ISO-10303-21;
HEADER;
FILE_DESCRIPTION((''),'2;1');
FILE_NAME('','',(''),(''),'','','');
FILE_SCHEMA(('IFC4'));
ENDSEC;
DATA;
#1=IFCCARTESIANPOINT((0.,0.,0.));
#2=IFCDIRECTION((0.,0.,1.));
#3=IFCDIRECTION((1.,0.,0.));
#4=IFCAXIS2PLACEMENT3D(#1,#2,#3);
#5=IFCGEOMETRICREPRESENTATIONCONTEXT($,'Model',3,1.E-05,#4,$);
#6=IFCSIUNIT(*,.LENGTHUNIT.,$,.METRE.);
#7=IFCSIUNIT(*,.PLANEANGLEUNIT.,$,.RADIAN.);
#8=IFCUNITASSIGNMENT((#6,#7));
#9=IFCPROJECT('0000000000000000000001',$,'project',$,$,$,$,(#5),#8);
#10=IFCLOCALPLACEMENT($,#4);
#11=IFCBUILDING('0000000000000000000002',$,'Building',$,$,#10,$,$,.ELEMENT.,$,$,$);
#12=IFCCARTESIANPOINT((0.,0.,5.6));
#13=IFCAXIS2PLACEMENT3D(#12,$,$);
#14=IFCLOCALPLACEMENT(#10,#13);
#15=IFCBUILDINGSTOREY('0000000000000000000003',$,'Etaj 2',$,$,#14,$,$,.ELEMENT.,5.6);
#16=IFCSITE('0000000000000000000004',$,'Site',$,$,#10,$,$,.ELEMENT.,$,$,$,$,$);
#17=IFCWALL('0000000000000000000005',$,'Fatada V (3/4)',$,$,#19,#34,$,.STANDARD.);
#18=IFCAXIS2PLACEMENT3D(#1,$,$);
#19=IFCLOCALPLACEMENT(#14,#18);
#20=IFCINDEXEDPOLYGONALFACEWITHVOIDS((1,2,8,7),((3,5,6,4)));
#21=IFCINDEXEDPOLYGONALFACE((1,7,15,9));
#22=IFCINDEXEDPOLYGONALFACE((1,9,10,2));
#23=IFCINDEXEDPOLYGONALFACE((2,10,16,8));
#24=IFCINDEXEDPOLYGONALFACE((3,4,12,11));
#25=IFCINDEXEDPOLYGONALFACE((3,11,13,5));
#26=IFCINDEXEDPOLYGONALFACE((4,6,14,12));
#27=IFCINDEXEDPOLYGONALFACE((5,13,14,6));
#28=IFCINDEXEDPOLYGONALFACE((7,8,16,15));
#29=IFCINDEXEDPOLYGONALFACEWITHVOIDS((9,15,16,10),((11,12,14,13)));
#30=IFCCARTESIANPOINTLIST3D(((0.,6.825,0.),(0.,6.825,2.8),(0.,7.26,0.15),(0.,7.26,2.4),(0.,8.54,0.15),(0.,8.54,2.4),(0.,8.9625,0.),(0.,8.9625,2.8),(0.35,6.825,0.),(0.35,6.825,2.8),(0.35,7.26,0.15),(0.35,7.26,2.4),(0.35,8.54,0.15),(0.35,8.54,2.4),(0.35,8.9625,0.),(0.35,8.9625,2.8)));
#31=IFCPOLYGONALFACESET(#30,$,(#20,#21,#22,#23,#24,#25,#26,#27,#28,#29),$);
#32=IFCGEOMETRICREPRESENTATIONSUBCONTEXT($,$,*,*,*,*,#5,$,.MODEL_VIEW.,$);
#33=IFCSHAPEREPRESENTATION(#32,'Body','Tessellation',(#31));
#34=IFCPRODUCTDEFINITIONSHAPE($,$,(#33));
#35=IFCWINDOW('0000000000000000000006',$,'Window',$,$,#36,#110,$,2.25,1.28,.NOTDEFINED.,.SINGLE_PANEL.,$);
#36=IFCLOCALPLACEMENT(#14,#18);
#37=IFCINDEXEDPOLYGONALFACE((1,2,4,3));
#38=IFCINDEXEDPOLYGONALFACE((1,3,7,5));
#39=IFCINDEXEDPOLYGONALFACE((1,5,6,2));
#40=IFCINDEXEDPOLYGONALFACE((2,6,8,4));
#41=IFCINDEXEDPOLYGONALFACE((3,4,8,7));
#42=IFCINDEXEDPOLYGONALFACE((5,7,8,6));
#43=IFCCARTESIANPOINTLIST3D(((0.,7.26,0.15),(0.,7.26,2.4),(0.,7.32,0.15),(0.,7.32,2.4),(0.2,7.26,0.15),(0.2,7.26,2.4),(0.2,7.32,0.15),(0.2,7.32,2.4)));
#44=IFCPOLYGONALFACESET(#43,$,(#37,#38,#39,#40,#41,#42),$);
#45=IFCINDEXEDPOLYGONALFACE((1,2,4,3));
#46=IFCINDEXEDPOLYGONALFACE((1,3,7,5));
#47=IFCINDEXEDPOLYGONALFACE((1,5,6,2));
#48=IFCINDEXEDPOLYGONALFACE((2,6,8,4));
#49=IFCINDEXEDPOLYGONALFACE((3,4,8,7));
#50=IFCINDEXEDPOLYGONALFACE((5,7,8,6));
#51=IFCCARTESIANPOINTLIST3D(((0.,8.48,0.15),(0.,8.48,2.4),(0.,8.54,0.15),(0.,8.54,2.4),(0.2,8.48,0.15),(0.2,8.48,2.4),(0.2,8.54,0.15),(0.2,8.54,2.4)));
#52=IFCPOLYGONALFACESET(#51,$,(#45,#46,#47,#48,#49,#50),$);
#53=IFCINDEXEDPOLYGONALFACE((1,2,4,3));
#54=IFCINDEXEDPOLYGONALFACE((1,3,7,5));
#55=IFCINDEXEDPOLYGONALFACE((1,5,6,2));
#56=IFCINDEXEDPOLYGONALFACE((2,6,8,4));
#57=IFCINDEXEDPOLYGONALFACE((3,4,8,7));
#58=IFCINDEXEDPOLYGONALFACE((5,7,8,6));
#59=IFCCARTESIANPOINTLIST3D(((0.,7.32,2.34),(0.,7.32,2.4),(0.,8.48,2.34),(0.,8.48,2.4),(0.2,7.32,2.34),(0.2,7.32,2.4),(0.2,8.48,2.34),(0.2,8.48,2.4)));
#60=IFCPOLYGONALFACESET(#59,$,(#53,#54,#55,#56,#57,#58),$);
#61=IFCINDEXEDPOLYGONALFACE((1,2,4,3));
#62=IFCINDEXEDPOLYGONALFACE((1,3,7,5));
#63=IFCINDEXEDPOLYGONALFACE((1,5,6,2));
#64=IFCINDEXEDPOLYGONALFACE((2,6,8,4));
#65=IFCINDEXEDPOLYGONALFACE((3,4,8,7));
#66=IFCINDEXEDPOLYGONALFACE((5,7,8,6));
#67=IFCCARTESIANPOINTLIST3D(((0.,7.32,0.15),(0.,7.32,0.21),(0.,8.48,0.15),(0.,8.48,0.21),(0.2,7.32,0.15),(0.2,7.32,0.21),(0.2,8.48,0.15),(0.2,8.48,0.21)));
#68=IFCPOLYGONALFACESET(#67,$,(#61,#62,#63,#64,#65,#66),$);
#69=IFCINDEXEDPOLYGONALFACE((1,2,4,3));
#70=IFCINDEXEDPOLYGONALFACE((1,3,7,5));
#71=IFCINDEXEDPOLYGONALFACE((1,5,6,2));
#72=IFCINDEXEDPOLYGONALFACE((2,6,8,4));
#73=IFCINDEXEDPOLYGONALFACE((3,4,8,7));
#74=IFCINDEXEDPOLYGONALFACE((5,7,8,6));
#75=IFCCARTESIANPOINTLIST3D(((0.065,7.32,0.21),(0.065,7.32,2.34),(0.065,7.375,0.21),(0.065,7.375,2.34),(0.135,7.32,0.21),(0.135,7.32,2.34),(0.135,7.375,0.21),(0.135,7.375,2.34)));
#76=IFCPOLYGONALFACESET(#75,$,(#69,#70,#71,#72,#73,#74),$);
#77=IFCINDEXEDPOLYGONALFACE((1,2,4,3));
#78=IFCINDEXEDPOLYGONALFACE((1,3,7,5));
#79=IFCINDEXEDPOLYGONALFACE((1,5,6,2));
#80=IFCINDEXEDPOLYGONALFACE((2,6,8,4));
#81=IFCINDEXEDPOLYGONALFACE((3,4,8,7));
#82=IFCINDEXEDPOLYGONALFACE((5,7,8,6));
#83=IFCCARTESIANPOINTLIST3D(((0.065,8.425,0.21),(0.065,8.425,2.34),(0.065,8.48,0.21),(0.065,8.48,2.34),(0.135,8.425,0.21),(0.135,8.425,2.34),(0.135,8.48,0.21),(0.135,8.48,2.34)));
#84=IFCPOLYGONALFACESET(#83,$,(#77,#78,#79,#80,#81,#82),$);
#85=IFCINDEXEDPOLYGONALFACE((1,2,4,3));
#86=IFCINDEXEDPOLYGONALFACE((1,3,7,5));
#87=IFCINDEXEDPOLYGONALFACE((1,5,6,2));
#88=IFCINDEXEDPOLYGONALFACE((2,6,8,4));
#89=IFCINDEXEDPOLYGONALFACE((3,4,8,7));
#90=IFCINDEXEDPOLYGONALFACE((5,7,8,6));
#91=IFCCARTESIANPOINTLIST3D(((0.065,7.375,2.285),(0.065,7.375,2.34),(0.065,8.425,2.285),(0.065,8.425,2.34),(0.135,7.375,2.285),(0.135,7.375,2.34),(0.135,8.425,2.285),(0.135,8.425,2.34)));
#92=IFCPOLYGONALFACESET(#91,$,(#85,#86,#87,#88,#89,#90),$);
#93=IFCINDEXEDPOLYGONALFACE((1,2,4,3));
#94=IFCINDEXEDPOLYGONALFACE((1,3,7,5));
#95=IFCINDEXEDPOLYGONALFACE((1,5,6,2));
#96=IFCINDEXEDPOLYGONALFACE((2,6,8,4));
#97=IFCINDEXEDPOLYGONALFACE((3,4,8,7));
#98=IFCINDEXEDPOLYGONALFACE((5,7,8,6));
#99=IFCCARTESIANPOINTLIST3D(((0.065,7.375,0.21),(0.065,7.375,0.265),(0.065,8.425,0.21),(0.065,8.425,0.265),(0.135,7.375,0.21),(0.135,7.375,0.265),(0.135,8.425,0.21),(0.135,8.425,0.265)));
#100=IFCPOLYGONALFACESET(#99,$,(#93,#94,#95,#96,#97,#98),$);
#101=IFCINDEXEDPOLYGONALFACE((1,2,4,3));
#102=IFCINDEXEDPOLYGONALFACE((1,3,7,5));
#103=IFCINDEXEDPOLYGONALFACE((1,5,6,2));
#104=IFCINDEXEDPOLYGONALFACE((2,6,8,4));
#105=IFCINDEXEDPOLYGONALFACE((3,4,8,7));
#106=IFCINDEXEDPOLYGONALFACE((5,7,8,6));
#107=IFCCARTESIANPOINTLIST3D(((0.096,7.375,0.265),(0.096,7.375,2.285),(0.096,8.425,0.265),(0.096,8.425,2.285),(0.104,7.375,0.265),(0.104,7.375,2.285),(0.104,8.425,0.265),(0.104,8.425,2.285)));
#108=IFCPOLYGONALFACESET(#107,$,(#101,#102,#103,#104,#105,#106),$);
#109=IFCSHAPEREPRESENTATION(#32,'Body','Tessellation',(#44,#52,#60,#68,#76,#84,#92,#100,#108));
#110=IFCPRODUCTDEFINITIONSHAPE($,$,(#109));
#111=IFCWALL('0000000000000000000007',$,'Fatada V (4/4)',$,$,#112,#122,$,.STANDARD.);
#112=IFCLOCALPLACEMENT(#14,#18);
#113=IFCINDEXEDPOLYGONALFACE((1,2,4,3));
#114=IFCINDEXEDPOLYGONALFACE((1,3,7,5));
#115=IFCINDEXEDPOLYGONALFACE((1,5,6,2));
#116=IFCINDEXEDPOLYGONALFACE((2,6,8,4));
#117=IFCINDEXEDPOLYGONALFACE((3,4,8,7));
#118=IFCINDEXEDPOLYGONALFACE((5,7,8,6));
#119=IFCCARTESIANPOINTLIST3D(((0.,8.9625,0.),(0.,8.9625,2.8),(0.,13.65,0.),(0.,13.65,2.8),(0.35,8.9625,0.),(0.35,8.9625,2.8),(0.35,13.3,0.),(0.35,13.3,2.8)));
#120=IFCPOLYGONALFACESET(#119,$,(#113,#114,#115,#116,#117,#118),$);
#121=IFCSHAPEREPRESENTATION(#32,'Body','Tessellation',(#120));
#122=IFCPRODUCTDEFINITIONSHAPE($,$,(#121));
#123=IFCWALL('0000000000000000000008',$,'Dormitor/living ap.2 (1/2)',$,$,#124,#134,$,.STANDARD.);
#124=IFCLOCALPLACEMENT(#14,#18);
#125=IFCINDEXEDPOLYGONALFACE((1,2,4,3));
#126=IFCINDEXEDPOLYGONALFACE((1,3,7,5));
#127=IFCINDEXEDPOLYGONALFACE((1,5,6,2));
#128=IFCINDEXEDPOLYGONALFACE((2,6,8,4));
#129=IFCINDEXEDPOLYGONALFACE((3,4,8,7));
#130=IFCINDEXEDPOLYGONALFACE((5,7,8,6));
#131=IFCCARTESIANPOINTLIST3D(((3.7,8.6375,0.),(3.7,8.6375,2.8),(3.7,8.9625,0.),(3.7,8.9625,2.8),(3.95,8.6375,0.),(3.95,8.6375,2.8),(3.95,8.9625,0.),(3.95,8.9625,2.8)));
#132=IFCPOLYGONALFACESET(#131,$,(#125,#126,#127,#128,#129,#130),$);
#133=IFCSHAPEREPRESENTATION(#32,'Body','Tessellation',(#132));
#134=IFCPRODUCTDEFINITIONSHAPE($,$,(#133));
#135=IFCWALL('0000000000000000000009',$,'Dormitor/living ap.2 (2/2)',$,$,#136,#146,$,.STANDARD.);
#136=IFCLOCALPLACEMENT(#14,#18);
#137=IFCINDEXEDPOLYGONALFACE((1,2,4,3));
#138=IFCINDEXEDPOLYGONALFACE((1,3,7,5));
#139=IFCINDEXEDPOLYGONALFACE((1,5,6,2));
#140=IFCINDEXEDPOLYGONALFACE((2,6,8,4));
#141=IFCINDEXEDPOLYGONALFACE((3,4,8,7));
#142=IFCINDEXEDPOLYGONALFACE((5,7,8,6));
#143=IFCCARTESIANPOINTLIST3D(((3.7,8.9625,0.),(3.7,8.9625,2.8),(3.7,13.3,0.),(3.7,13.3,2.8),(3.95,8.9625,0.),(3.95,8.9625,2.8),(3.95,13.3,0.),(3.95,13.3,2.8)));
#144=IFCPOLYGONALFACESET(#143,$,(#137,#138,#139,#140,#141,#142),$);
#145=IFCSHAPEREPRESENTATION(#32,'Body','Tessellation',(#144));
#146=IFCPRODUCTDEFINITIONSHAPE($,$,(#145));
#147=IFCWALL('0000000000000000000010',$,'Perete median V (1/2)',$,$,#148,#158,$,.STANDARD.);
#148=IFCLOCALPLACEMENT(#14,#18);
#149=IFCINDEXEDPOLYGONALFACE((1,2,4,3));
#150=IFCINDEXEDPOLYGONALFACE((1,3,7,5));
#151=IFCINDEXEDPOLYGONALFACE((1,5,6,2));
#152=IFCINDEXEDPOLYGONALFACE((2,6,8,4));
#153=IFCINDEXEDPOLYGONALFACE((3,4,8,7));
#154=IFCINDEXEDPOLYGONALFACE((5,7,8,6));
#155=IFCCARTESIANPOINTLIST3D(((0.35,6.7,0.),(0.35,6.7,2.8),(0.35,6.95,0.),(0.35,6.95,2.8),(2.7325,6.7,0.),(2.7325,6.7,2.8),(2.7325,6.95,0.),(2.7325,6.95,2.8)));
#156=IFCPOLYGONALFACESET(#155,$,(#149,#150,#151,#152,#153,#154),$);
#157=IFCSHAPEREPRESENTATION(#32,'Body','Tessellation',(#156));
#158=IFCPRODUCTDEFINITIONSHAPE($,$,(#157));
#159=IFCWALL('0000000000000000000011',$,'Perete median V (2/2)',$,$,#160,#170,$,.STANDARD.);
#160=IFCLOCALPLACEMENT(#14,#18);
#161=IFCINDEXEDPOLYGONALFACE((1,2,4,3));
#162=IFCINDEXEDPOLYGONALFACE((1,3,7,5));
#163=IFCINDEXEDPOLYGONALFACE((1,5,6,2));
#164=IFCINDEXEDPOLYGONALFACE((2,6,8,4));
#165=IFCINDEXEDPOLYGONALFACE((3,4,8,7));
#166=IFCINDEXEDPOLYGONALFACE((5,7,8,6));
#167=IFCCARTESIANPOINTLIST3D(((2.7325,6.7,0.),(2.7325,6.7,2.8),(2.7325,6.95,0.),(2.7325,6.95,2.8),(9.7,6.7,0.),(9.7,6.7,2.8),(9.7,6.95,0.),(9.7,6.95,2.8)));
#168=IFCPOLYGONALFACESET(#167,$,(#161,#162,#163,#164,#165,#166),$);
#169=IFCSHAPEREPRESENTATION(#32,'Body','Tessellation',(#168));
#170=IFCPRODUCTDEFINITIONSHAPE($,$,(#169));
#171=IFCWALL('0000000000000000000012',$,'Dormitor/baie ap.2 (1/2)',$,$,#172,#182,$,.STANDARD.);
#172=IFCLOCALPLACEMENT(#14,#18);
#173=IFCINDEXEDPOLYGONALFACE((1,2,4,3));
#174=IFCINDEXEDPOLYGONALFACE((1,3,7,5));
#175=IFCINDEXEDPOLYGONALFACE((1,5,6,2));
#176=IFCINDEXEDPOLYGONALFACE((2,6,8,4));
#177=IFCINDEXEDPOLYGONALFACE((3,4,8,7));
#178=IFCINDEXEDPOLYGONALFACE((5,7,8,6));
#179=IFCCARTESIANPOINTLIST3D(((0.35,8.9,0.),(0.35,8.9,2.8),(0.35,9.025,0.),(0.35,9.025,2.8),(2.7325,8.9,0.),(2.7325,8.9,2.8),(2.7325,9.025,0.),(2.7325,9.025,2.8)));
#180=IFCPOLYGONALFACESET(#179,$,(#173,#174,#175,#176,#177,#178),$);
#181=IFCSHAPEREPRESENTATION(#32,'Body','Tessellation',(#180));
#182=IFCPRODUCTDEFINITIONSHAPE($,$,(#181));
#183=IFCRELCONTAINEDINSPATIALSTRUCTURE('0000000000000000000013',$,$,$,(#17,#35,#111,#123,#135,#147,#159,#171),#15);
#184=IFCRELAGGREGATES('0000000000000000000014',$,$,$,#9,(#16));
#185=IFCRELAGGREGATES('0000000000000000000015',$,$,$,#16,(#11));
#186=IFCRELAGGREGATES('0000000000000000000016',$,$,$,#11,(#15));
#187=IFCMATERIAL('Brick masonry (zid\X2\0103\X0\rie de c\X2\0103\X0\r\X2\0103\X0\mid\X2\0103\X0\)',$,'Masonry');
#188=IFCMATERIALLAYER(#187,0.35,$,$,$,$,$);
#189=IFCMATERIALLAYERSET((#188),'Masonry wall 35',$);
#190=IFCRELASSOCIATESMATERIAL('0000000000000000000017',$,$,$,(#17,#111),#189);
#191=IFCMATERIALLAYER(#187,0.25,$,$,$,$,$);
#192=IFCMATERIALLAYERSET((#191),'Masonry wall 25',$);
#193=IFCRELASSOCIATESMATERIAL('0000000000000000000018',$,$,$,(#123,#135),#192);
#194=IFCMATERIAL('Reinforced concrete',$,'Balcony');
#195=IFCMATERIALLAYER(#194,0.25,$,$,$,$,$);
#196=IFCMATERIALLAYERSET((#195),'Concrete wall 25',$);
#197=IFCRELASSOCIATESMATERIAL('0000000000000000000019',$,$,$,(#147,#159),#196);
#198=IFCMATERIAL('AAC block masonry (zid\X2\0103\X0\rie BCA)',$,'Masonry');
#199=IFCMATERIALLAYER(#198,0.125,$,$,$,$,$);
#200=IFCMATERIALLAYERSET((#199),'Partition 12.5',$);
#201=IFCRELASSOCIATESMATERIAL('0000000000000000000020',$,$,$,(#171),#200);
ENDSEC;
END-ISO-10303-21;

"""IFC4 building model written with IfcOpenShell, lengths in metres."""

from ifc_helpers import new_model, si_unit, frame, frame_2d, origin, origin_with_axes, origin_2d, place, context, subcontext, project, spatial, rectangle, extrude, clip, halfspace, material, layer, layer_set, layer_usage, element, fill, save


model = new_model("IFC4")

# Units and contexts
model_context = context("Model", 3, precision=1e-05, world=origin_with_axes())
sub_context = subcontext(model_context, None, None, "MODEL_VIEW")
ifc_project = project(units=[si_unit("LENGTHUNIT", "METRE"), si_unit("PLANEANGLEUNIT", "RADIAN")], contexts=[model_context])

# Site, building, storey
placement = place(None, origin_with_axes())
site = spatial("IfcSite", under=ifc_project, at=placement, Name="Site", CompositionType="ELEMENT")
building = spatial("IfcBuilding", under=site, at=placement, Name="Building", CompositionType="ELEMENT")
storey_placement = place(placement, frame((0.0, 0.0, 5.6)))
storey = spatial("IfcBuildingStorey", under=building, at=storey_placement, Name="Etaj 2", CompositionType="ELEMENT", Elevation=5.6)

# Wall, opening, window
ifc_material_1 = material(Name="Brick masonry (zidărie de cărămidă)", Category="Masonry")
ifc_layer_1 = layer(ifc_material_1, 0.35)
ifc_layer_set_1 = layer_set([ifc_layer_1], Name="Masonry wall 35")
ifc_layer_usage_1 = layer_usage(ifc_layer_set_1, "AXIS2", "POSITIVE", -0.175)
wall_1_placement = place(storey_placement, frame((0.175, 6.825, 0.0), x_axis=(0.0, 1.0, 0.0)))
wall_1 = element("IfcWall", 1, at=wall_1_placement, inside=storey, material=ifc_layer_usage_1, Name="Fatada V (3/4)", PredefinedType="STANDARD", context=sub_context, shape_type="SweptSolid", body=[
    extrude(rectangle(XDim=2.1375, YDim=0.35, at=frame_2d((1.0688, 0.0))), origin(), (0.0, 0.0, 1.0), 2.8),
])
opening_1_placement = place(wall_1_placement, frame((1.075, 0.225, 0.15), z_axis=(0.0, -1.0, 0.0), x_axis=(1.0, 0.0, 0.0)))
opening_1 = element("IfcOpeningElement", 2, at=opening_1_placement, cuts=wall_1, PredefinedType="OPENING", context=sub_context, shape_type="SweptSolid", body=[
    extrude(rectangle(XDim=1.28, YDim=2.25, at=frame_2d((0.0, 1.125))), origin(), (0.0, 0.0, 1.0), 0.45),
])
window_1_placement = place(wall_1_placement, frame((1.075, 0.175, 0.15), z_axis=(0.0, -1.0, 0.0), x_axis=(1.0, 0.0, 0.0)))
window_1 = element("IfcWindow", 3, at=window_1_placement, inside=storey, Name="Window", OverallHeight=2.25, OverallWidth=1.28, PartitioningType="SINGLE_PANEL", PredefinedType="NOTDEFINED", context=sub_context, shape_type="SweptSolid", body=[
    extrude(rectangle(XDim=0.06, YDim=2.25, at=origin_2d()), frame((-0.61, 1.125, 0.0)), (0.0, 0.0, 1.0), 0.2),
    extrude(rectangle(XDim=0.06, YDim=2.25, at=origin_2d()), frame((0.61, 1.125, 0.0)), (0.0, 0.0, 1.0), 0.2),
    extrude(rectangle(XDim=1.16, YDim=0.06, at=origin_2d()), frame((0.0, 2.22, 0.0)), (0.0, 0.0, 1.0), 0.2),
    extrude(rectangle(XDim=1.16, YDim=0.06, at=origin_2d()), frame((0.0, 0.03, 0.0)), (0.0, 0.0, 1.0), 0.2),
    extrude(rectangle(XDim=0.055, YDim=2.13, at=origin_2d()), frame((-0.5525, 1.125, 0.065)), (0.0, 0.0, 1.0), 0.07),
    extrude(rectangle(XDim=0.055, YDim=2.13, at=origin_2d()), frame((0.5525, 1.125, 0.065)), (0.0, 0.0, 1.0), 0.07),
    extrude(rectangle(XDim=1.05, YDim=0.055, at=origin_2d()), frame((0.0, 2.1625, 0.065)), (0.0, 0.0, 1.0), 0.07),
    extrude(rectangle(XDim=1.05, YDim=0.055, at=origin_2d()), frame((0.0, 0.0875, 0.065)), (0.0, 0.0, 1.0), 0.07),
    extrude(rectangle(XDim=1.05, YDim=2.02, at=origin_2d()), frame((0.0, 1.125, 0.096)), (0.0, 0.0, 1.0), 0.008),
])
fill(opening_1, window_1)

# Walls
wall_2_placement = place(storey_placement, frame((0.175, 8.9625, 0.0), x_axis=(0.0, 1.0, 0.0)))
element("IfcWall", 4, at=wall_2_placement, inside=storey, material=ifc_layer_usage_1, Name="Fatada V (4/4)", PredefinedType="STANDARD", context=sub_context, shape_type="CSG", body=[
    clip(extrude(rectangle(XDim=4.6875, YDim=0.35, at=frame_2d((2.3438, 0.0))), origin(), (0.0, 0.0, 1.0), 2.8), halfspace(frame((4.5125, 0.0, 0.0), z_axis=(0.707107, -0.707107, 0.0)), False)),
])
ifc_layer_2 = layer(ifc_material_1, 0.25)
ifc_layer_set_2 = layer_set([ifc_layer_2], Name="Masonry wall 25")
ifc_layer_usage_2 = layer_usage(ifc_layer_set_2, "AXIS2", "POSITIVE", -0.125)
wall_3_placement = place(storey_placement, frame((3.825, 8.6375, 0.0), x_axis=(0.0, 1.0, 0.0)))
element("IfcWall", 5, at=wall_3_placement, inside=storey, material=ifc_layer_usage_2, Name="Dormitor/living ap.2 (1/2)", PredefinedType="STANDARD", context=sub_context, shape_type="SweptSolid", body=[
    extrude(rectangle(XDim=0.325, YDim=0.25, at=frame_2d((0.1625, 0.0))), origin(), (0.0, 0.0, 1.0), 2.8),
])
wall_4_placement = place(storey_placement, frame((3.825, 8.9625, 0.0), x_axis=(0.0, 1.0, 0.0)))
element("IfcWall", 6, at=wall_4_placement, inside=storey, material=ifc_layer_usage_2, Name="Dormitor/living ap.2 (2/2)", PredefinedType="STANDARD", context=sub_context, shape_type="SweptSolid", body=[
    extrude(rectangle(XDim=4.3375, YDim=0.25, at=frame_2d((2.1688, 0.0))), origin(), (0.0, 0.0, 1.0), 2.8),
])
ifc_material_2 = material(Name="Reinforced concrete", Category="Balcony")
ifc_layer_3 = layer(ifc_material_2, 0.25)
ifc_layer_set_3 = layer_set([ifc_layer_3], Name="Concrete wall 25")
ifc_layer_usage_3 = layer_usage(ifc_layer_set_3, "AXIS2", "POSITIVE", -0.125)
wall_5_placement = place(storey_placement, frame((0.35, 6.825, 0.0), x_axis=(1.0, 0.0, 0.0)))
element("IfcWall", 7, at=wall_5_placement, inside=storey, material=ifc_layer_usage_3, Name="Perete median V (1/2)", PredefinedType="STANDARD", context=sub_context, shape_type="SweptSolid", body=[
    extrude(rectangle(XDim=2.3825, YDim=0.25, at=frame_2d((1.1912, 0.0))), origin(), (0.0, 0.0, 1.0), 2.8),
])
wall_6_placement = place(storey_placement, frame((2.7325, 6.825, 0.0), x_axis=(1.0, 0.0, 0.0)))
element("IfcWall", 8, at=wall_6_placement, inside=storey, material=ifc_layer_usage_3, Name="Perete median V (2/2)", PredefinedType="STANDARD", context=sub_context, shape_type="SweptSolid", body=[
    extrude(rectangle(XDim=6.9675, YDim=0.25, at=frame_2d((3.4838, 0.0))), origin(), (0.0, 0.0, 1.0), 2.8),
])
ifc_material_3 = material(Name="AAC block masonry (zidărie BCA)", Category="Masonry")
ifc_layer_4 = layer(ifc_material_3, 0.125)
ifc_layer_set_4 = layer_set([ifc_layer_4], Name="Partition 12.5")
ifc_layer_usage_4 = layer_usage(ifc_layer_set_4, "AXIS2", "POSITIVE", -0.0625)
wall_7_placement = place(storey_placement, frame((0.35, 8.9625, 0.0), x_axis=(1.0, 0.0, 0.0)))
element("IfcWall", 9, at=wall_7_placement, inside=storey, material=ifc_layer_usage_4, Name="Dormitor/baie ap.2 (1/2)", PredefinedType="STANDARD", context=sub_context, shape_type="SweptSolid", body=[
    extrude(rectangle(XDim=2.3825, YDim=0.125, at=frame_2d((1.1912, 0.0))), origin(), (0.0, 0.0, 1.0), 2.8),
])

save(model, "model.ifc")
